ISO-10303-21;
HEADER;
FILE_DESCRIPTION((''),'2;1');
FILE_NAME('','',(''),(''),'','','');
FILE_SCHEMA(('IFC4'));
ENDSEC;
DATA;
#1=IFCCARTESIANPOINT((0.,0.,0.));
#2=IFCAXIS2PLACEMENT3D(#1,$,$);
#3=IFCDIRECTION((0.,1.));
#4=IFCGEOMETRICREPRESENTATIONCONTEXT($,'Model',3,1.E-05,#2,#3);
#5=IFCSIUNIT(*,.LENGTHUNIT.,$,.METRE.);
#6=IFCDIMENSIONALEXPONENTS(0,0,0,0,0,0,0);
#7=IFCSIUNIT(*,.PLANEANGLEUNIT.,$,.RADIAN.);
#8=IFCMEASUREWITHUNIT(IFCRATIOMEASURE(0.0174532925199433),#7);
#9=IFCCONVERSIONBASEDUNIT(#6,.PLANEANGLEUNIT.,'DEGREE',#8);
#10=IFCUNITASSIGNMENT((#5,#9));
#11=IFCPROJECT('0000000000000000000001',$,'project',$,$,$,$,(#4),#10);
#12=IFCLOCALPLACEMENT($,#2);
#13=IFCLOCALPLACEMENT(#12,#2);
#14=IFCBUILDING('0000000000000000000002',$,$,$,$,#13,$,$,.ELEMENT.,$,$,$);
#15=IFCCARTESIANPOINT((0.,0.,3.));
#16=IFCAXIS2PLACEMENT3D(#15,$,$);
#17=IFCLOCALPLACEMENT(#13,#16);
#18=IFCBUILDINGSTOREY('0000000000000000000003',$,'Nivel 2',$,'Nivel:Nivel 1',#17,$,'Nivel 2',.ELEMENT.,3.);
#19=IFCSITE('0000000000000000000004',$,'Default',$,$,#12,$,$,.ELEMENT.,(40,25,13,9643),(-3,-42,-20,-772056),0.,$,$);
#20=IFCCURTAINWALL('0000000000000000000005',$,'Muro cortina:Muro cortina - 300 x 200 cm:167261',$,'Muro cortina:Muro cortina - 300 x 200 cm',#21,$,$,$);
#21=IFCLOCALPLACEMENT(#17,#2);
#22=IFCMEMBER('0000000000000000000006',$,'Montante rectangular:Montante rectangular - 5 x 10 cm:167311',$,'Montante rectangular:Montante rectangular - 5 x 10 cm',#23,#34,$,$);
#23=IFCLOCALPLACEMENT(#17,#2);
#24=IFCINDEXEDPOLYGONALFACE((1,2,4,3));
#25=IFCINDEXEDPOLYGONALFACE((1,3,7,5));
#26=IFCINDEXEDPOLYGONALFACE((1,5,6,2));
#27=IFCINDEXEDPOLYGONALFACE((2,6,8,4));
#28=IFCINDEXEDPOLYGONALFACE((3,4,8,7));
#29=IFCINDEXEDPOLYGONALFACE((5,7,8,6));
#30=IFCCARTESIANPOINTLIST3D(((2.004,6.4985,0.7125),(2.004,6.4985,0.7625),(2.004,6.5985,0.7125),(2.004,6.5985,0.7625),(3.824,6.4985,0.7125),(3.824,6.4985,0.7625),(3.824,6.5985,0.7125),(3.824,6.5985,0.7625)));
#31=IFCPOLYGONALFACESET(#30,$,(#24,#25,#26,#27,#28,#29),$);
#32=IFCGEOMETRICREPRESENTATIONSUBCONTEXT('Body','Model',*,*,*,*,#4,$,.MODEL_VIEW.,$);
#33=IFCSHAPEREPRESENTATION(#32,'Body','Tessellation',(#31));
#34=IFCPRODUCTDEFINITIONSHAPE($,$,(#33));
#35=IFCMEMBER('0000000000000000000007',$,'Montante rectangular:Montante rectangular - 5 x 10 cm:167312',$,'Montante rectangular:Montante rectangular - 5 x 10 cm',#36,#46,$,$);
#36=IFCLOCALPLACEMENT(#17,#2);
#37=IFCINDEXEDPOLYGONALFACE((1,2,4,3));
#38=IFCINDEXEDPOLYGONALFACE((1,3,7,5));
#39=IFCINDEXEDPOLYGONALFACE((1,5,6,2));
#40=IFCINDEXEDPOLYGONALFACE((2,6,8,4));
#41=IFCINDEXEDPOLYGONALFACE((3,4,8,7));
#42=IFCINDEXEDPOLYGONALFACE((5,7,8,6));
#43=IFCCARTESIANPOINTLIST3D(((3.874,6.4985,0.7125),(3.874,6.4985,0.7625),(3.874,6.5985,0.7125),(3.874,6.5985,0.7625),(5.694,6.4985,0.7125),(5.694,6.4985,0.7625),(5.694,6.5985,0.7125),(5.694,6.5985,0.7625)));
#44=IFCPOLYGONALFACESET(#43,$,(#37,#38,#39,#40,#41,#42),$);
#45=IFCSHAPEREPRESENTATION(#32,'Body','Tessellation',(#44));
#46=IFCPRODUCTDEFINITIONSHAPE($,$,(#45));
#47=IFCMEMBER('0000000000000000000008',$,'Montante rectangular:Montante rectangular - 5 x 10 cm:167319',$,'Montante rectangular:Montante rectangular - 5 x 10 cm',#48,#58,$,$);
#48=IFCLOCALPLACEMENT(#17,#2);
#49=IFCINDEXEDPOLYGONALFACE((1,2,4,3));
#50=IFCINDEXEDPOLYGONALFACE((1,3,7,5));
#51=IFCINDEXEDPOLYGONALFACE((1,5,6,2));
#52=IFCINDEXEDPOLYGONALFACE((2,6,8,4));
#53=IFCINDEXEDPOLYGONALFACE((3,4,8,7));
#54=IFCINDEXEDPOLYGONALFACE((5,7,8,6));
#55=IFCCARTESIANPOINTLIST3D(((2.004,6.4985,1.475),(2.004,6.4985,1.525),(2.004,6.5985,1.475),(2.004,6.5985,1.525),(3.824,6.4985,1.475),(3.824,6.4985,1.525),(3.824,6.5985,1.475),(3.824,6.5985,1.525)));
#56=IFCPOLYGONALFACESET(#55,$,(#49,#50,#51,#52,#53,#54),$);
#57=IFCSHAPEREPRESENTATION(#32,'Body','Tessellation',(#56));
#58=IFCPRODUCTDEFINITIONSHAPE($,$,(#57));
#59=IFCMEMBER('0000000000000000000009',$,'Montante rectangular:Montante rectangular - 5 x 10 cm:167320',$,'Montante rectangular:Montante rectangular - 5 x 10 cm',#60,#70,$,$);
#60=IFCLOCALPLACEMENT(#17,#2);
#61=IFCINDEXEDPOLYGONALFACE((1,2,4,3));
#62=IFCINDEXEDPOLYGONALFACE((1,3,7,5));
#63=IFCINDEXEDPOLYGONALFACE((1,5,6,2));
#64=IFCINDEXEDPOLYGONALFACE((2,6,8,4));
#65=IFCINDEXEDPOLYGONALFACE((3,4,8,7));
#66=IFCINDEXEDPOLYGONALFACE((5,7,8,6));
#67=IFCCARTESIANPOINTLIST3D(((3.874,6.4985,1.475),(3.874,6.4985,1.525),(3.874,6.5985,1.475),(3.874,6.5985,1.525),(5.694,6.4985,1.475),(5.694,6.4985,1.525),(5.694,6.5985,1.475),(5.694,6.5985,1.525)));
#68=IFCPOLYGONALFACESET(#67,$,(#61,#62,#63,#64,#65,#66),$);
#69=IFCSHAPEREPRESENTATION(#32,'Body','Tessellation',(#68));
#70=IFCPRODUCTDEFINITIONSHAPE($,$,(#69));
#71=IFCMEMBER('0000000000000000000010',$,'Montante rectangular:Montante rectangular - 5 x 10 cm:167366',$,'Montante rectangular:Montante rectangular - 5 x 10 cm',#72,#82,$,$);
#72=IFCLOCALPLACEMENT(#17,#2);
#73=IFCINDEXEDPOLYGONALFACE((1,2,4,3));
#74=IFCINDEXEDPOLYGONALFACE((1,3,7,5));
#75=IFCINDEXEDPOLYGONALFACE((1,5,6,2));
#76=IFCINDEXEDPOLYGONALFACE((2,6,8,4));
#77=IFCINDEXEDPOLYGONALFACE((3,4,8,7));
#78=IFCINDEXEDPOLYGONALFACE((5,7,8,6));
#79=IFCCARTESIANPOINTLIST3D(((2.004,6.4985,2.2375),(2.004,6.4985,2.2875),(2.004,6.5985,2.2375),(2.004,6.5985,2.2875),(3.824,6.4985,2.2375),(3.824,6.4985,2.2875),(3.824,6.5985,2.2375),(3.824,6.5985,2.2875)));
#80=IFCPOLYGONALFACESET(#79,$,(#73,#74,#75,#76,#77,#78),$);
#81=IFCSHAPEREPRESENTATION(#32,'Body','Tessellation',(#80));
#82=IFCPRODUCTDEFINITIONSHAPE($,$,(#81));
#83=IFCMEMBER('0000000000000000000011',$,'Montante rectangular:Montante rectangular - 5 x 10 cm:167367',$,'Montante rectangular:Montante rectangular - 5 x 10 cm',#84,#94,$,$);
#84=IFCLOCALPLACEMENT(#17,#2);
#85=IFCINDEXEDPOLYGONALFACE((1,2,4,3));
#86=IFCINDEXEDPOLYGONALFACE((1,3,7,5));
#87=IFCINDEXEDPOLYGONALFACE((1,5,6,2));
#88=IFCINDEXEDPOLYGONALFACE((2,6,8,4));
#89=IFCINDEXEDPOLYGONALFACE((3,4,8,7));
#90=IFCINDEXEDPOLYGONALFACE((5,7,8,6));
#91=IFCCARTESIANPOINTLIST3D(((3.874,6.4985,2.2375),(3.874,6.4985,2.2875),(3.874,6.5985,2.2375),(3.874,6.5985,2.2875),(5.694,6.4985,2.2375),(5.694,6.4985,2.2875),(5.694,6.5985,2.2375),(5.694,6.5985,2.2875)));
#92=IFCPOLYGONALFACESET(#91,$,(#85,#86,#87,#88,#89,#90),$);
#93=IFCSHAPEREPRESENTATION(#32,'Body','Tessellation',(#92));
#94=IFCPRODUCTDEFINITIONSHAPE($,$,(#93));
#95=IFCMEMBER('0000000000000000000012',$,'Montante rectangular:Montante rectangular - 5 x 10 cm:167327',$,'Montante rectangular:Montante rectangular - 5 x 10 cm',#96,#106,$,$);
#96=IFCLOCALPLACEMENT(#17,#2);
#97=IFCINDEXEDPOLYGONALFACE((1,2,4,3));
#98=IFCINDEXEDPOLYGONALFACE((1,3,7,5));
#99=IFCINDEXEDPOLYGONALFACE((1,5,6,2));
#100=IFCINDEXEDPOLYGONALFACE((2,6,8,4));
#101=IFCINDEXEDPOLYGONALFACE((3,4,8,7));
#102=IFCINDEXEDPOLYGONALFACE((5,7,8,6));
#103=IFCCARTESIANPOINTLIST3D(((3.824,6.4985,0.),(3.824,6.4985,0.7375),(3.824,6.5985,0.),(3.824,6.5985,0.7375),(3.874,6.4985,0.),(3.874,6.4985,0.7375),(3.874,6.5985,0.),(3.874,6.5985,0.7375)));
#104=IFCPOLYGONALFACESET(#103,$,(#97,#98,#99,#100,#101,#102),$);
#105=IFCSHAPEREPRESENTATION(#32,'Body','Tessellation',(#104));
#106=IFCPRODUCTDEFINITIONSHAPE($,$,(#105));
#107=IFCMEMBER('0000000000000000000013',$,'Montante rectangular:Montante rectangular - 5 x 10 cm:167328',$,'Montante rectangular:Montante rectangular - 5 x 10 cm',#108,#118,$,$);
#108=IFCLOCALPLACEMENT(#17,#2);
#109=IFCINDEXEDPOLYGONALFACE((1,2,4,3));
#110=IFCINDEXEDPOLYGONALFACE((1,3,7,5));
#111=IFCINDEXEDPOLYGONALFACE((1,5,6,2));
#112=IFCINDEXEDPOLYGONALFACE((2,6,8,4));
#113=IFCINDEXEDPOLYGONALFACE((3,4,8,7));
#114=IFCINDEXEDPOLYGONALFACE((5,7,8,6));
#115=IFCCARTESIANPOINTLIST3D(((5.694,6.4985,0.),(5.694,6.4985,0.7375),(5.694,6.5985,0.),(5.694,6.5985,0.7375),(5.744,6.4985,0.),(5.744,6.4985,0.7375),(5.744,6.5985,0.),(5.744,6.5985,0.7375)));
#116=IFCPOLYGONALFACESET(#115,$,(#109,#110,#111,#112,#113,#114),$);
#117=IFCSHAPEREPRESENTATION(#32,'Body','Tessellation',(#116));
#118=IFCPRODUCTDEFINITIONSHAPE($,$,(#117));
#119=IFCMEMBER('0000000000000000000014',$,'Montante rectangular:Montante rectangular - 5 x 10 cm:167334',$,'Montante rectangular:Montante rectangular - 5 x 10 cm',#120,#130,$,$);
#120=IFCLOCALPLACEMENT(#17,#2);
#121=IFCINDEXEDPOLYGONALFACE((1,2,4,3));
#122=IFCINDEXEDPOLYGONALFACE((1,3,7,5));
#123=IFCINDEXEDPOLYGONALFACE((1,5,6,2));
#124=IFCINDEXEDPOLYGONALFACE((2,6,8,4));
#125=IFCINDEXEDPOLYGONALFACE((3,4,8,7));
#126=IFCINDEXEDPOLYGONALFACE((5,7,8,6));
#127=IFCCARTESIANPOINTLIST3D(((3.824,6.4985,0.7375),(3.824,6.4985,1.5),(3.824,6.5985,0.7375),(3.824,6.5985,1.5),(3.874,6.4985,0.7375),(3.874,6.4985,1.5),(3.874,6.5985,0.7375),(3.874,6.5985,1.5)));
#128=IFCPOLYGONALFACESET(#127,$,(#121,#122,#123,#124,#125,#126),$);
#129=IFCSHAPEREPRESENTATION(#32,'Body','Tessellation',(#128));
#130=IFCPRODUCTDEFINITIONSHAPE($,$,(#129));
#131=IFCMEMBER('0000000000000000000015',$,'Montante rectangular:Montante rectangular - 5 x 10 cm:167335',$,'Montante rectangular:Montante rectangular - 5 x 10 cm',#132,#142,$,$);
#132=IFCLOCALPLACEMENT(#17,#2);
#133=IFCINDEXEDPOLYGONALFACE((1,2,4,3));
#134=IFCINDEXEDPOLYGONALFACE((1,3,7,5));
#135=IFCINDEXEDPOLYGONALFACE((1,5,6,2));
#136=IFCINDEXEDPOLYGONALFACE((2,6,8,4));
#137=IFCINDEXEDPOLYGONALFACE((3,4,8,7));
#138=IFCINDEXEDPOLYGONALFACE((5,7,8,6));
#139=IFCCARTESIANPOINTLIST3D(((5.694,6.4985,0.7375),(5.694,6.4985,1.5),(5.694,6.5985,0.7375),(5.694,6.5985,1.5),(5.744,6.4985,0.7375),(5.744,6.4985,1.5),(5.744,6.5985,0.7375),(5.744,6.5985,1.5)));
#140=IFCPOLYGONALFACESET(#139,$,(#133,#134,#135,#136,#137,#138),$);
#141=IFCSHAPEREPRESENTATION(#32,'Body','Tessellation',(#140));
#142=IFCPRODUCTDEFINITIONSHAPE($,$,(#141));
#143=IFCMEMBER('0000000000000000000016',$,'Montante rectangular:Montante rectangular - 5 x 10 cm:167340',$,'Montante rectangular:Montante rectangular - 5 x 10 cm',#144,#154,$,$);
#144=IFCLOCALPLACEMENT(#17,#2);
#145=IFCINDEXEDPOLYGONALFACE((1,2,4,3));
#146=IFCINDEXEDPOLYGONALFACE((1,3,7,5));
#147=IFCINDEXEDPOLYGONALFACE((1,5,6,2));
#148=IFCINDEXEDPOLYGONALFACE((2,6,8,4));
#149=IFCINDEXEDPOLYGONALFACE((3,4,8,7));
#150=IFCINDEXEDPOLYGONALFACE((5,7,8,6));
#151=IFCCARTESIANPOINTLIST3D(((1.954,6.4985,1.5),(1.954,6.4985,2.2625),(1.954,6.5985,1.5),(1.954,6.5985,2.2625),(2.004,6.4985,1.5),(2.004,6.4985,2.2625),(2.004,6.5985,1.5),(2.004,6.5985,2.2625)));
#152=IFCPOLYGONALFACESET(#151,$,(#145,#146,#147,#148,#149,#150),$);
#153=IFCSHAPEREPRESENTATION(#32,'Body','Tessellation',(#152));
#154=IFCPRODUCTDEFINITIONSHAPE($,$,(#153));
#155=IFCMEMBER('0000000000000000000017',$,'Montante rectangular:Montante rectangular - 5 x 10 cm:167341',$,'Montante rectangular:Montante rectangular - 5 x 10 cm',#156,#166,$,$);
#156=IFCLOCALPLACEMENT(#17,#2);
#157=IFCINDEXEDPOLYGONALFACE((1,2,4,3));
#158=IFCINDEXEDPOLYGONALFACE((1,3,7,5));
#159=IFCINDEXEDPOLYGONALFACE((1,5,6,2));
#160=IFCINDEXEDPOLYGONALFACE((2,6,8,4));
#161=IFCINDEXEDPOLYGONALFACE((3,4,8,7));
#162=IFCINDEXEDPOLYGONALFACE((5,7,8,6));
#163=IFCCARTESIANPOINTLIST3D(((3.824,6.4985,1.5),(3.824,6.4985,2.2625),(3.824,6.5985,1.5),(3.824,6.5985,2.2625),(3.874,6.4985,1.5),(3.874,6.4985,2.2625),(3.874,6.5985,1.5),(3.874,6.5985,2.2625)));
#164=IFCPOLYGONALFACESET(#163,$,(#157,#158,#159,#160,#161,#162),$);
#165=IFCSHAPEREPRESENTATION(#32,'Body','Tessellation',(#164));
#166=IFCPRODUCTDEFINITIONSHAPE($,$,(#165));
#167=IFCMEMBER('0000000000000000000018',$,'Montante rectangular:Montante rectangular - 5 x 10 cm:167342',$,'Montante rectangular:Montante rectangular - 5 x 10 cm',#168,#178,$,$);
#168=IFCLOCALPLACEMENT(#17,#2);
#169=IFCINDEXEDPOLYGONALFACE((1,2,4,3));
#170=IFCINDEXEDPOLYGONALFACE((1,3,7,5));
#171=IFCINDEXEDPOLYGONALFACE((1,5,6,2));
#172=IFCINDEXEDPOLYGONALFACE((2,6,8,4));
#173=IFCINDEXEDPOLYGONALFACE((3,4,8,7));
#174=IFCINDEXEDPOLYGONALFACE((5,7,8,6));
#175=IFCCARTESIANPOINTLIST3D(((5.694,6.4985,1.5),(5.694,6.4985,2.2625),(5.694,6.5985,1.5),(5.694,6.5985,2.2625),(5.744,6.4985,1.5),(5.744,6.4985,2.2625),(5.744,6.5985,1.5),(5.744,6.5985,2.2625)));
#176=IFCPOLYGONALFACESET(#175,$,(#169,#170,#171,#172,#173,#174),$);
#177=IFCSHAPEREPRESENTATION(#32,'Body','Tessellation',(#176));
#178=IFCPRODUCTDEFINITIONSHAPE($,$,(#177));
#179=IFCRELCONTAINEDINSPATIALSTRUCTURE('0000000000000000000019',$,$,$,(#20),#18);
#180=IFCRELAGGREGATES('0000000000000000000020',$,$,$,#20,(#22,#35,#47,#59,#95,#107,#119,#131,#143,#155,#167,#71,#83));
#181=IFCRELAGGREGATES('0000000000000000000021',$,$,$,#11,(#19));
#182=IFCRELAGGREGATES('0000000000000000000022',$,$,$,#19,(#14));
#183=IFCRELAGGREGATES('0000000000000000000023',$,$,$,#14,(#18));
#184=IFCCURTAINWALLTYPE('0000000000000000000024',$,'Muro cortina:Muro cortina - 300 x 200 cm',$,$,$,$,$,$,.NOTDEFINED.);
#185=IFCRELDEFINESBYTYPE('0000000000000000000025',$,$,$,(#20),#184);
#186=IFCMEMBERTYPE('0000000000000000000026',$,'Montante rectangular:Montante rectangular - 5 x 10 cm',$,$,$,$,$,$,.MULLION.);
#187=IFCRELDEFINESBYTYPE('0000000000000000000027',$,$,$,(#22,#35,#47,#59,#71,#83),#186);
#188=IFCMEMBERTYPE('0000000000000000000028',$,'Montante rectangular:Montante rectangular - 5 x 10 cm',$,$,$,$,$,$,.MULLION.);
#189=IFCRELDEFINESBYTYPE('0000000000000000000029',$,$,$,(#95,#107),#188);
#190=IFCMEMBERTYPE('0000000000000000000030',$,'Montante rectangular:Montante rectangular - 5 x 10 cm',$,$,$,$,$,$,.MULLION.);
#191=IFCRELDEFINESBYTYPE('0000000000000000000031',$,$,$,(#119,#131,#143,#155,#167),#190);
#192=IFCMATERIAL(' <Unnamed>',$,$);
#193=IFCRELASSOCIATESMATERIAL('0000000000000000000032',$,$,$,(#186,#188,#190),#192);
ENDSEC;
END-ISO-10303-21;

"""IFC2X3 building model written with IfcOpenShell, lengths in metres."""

from ifc_helpers import new_model, entity, si_unit, converted_unit, direction, frame, origin, origin_2d_with_axis, place, context, subcontext, project, spatial, rectangle, extrude, source, transform, mapped, material, type_object, type_shapes, element, aggregate, save


model = new_model("IFC2X3")

# Units and contexts
model_context = context("Model", 3, precision=1e-05, world=origin(), true_north=direction((0.0, 1.0)))
body_context = subcontext(model_context, "Body", "Model", "MODEL_VIEW")
ifc_project = project(units=[si_unit("LENGTHUNIT", "METRE"), converted_unit("PLANEANGLEUNIT", "DEGREE", entity("IfcRatioMeasure", 0.0174532925199433), si_unit("PLANEANGLEUNIT", "RADIAN"), dimensions=[0, 0, 0, 0, 0, 0, 0])], contexts=[model_context])

# Site, building, storey
site_placement = place(None, origin())
site = spatial("IfcSite", under=ifc_project, at=site_placement, Name="Default", CompositionType="ELEMENT", RefLatitude=(40, 25, 13, 9643), RefLongitude=(-3, -42, -20, -772056), RefElevation=0.0)
building_placement = place(site_placement, origin())
building = spatial("IfcBuilding", under=site, at=building_placement, CompositionType="ELEMENT")
storey_placement = place(building_placement, frame((0.0, 0.0, 3.0)))
storey = spatial("IfcBuildingStorey", under=building, at=storey_placement, Name="Nivel 2", ObjectType="Nivel:Nivel 1", LongName="Nivel 2", CompositionType="ELEMENT", Elevation=3.0)

# Curtain wall, members
curtain_wall_type = type_object("IfcCurtainWallType", Name="Muro cortina:Muro cortina - 300 x 200 cm", PredefinedType="NOTDEFINED")
curtain_wall_placement = place(storey_placement, frame((0.0, 0.0, -3.0)))
curtain_wall = element("IfcCurtainWall", 1, at=curtain_wall_placement, inside=storey, type_object=curtain_wall_type, Name="Muro cortina:Muro cortina - 300 x 200 cm:167261", ObjectType="Muro cortina:Muro cortina - 300 x 200 cm")
ifc_material_1 = material(Name=" <Unnamed>")
member_type_1 = type_object("IfcMemberType", Name="Montante rectangular:Montante rectangular - 5 x 10 cm", PredefinedType="MULLION", material=ifc_material_1)
shared_shape_1 = source(origin(), body_context, "Body", "SweptSolid", [
    extrude(rectangle(XDim=0.1, YDim=0.05, at=origin_2d_with_axis()), frame((0.0, 0.0, -1.82), z_axis=(0.0, 0.0, 1.0), x_axis=(0.0, -1.0, 0.0)), (0.0, 0.0, 1.0), 1.82),
])
type_shapes(member_type_1, [shared_shape_1])
member_1_placement = place(storey_placement, frame((3.824, 6.5485, 0.7375), z_axis=(1.0, 0.0, 0.0), x_axis=(0.0, 0.0, 1.0)))
member_1 = element("IfcMember", 2, at=member_1_placement, type_object=member_type_1, Name="Montante rectangular:Montante rectangular - 5 x 10 cm:167311", ObjectType="Montante rectangular:Montante rectangular - 5 x 10 cm", context=body_context, shape_type="MappedRepresentation", body=[
    mapped(shared_shape_1, transform((0.0, 0.0, 0.0), scale=1.0)),
])
member_2_placement = place(storey_placement, frame((5.694, 6.5485, 0.7375), z_axis=(1.0, 0.0, 0.0), x_axis=(0.0, 0.0, 1.0)))
member_2 = element("IfcMember", 3, at=member_2_placement, type_object=member_type_1, Name="Montante rectangular:Montante rectangular - 5 x 10 cm:167312", ObjectType="Montante rectangular:Montante rectangular - 5 x 10 cm", context=body_context, shape_type="MappedRepresentation", body=[
    mapped(shared_shape_1, transform((0.0, 0.0, 0.0), scale=1.0)),
])
member_3_placement = place(storey_placement, frame((3.824, 6.5485, 1.5), z_axis=(1.0, 0.0, 0.0), x_axis=(0.0, 0.0, 1.0)))
member_3 = element("IfcMember", 4, at=member_3_placement, type_object=member_type_1, Name="Montante rectangular:Montante rectangular - 5 x 10 cm:167319", ObjectType="Montante rectangular:Montante rectangular - 5 x 10 cm", context=body_context, shape_type="MappedRepresentation", body=[
    mapped(shared_shape_1, transform((0.0, 0.0, 0.0), scale=1.0)),
])
member_4_placement = place(storey_placement, frame((5.694, 6.5485, 1.5), z_axis=(1.0, 0.0, 0.0), x_axis=(0.0, 0.0, 1.0)))
member_4 = element("IfcMember", 5, at=member_4_placement, type_object=member_type_1, Name="Montante rectangular:Montante rectangular - 5 x 10 cm:167320", ObjectType="Montante rectangular:Montante rectangular - 5 x 10 cm", context=body_context, shape_type="MappedRepresentation", body=[
    mapped(shared_shape_1, transform((0.0, 0.0, 0.0), scale=1.0)),
])
member_5_placement = place(storey_placement, frame((3.824, 6.5485, 2.2625), z_axis=(1.0, 0.0, 0.0), x_axis=(0.0, 0.0, 1.0)))
member_5 = element("IfcMember", 6, at=member_5_placement, type_object=member_type_1, Name="Montante rectangular:Montante rectangular - 5 x 10 cm:167366", ObjectType="Montante rectangular:Montante rectangular - 5 x 10 cm", context=body_context, shape_type="MappedRepresentation", body=[
    mapped(shared_shape_1, transform((0.0, 0.0, 0.0), scale=1.0)),
])
member_6_placement = place(storey_placement, frame((5.694, 6.5485, 2.2625), z_axis=(1.0, 0.0, 0.0), x_axis=(0.0, 0.0, 1.0)))
member_6 = element("IfcMember", 7, at=member_6_placement, type_object=member_type_1, Name="Montante rectangular:Montante rectangular - 5 x 10 cm:167367", ObjectType="Montante rectangular:Montante rectangular - 5 x 10 cm", context=body_context, shape_type="MappedRepresentation", body=[
    mapped(shared_shape_1, transform((0.0, 0.0, 0.0), scale=1.0)),
])
member_type_2 = type_object("IfcMemberType", Name="Montante rectangular:Montante rectangular - 5 x 10 cm", PredefinedType="MULLION", material=ifc_material_1)
shared_shape_2 = source(origin(), body_context, "Body", "SweptSolid", [
    extrude(rectangle(XDim=0.1, YDim=0.05, at=origin_2d_with_axis()), frame((0.0, 0.0, -0.7375), z_axis=(0.0, 0.0, 1.0), x_axis=(0.0, -1.0, 0.0)), (0.0, 0.0, 1.0), 0.7375),
])
type_shapes(member_type_2, [shared_shape_2])
member_7_placement = place(storey_placement, frame((3.849, 6.5485, 0.0), z_axis=(0.0, 0.0, -1.0), x_axis=(1.0, 0.0, 0.0)))
member_7 = element("IfcMember", 8, at=member_7_placement, type_object=member_type_2, Name="Montante rectangular:Montante rectangular - 5 x 10 cm:167327", ObjectType="Montante rectangular:Montante rectangular - 5 x 10 cm", context=body_context, shape_type="MappedRepresentation", body=[
    mapped(shared_shape_2, transform((0.0, 0.0, 0.0), scale=1.0)),
])
member_8_placement = place(storey_placement, frame((5.719, 6.5485, 0.0), z_axis=(0.0, 0.0, -1.0), x_axis=(1.0, 0.0, 0.0)))
member_8 = element("IfcMember", 9, at=member_8_placement, type_object=member_type_2, Name="Montante rectangular:Montante rectangular - 5 x 10 cm:167328", ObjectType="Montante rectangular:Montante rectangular - 5 x 10 cm", context=body_context, shape_type="MappedRepresentation", body=[
    mapped(shared_shape_2, transform((0.0, 0.0, 0.0), scale=1.0)),
])
member_type_3 = type_object("IfcMemberType", Name="Montante rectangular:Montante rectangular - 5 x 10 cm", PredefinedType="MULLION", material=ifc_material_1)
shared_shape_3 = source(origin(), body_context, "Body", "SweptSolid", [
    extrude(rectangle(XDim=0.1, YDim=0.05, at=origin_2d_with_axis()), frame((0.0, 0.0, -0.7625), z_axis=(0.0, 0.0, 1.0), x_axis=(0.0, -1.0, 0.0)), (0.0, 0.0, 1.0), 0.7625),
])
type_shapes(member_type_3, [shared_shape_3])
member_9_placement = place(storey_placement, frame((3.849, 6.5485, 0.7375), z_axis=(0.0, 0.0, -1.0), x_axis=(1.0, 0.0, 0.0)))
member_9 = element("IfcMember", 10, at=member_9_placement, type_object=member_type_3, Name="Montante rectangular:Montante rectangular - 5 x 10 cm:167334", ObjectType="Montante rectangular:Montante rectangular - 5 x 10 cm", context=body_context, shape_type="MappedRepresentation", body=[
    mapped(shared_shape_3, transform((0.0, 0.0, 0.0), scale=1.0)),
])
member_10_placement = place(storey_placement, frame((5.719, 6.5485, 0.7375), z_axis=(0.0, 0.0, -1.0), x_axis=(1.0, 0.0, 0.0)))
member_10 = element("IfcMember", 11, at=member_10_placement, type_object=member_type_3, Name="Montante rectangular:Montante rectangular - 5 x 10 cm:167335", ObjectType="Montante rectangular:Montante rectangular - 5 x 10 cm", context=body_context, shape_type="MappedRepresentation", body=[
    mapped(shared_shape_3, transform((0.0, 0.0, 0.0), scale=1.0)),
])
member_11_placement = place(storey_placement, frame((1.979, 6.5485, 1.5), z_axis=(0.0, 0.0, -1.0), x_axis=(1.0, 0.0, 0.0)))
member_11 = element("IfcMember", 12, at=member_11_placement, type_object=member_type_3, Name="Montante rectangular:Montante rectangular - 5 x 10 cm:167340", ObjectType="Montante rectangular:Montante rectangular - 5 x 10 cm", context=body_context, shape_type="MappedRepresentation", body=[
    mapped(shared_shape_3, transform((0.0, 0.0, 0.0), scale=1.0)),
])
member_12_placement = place(storey_placement, frame((3.849, 6.5485, 1.5), z_axis=(0.0, 0.0, -1.0), x_axis=(1.0, 0.0, 0.0)))
member_12 = element("IfcMember", 13, at=member_12_placement, type_object=member_type_3, Name="Montante rectangular:Montante rectangular - 5 x 10 cm:167341", ObjectType="Montante rectangular:Montante rectangular - 5 x 10 cm", context=body_context, shape_type="MappedRepresentation", body=[
    mapped(shared_shape_3, transform((0.0, 0.0, 0.0), scale=1.0)),
])
member_13_placement = place(storey_placement, frame((5.719, 6.5485, 1.5), z_axis=(0.0, 0.0, -1.0), x_axis=(1.0, 0.0, 0.0)))
member_13 = element("IfcMember", 14, at=member_13_placement, type_object=member_type_3, Name="Montante rectangular:Montante rectangular - 5 x 10 cm:167342", ObjectType="Montante rectangular:Montante rectangular - 5 x 10 cm", context=body_context, shape_type="MappedRepresentation", body=[
    mapped(shared_shape_3, transform((0.0, 0.0, 0.0), scale=1.0)),
])
aggregate(curtain_wall, [member_1, member_2, member_3, member_4, member_7, member_8, member_9, member_10, member_11, member_12, member_13, member_5, member_6])

save(model, "model.ifc")
